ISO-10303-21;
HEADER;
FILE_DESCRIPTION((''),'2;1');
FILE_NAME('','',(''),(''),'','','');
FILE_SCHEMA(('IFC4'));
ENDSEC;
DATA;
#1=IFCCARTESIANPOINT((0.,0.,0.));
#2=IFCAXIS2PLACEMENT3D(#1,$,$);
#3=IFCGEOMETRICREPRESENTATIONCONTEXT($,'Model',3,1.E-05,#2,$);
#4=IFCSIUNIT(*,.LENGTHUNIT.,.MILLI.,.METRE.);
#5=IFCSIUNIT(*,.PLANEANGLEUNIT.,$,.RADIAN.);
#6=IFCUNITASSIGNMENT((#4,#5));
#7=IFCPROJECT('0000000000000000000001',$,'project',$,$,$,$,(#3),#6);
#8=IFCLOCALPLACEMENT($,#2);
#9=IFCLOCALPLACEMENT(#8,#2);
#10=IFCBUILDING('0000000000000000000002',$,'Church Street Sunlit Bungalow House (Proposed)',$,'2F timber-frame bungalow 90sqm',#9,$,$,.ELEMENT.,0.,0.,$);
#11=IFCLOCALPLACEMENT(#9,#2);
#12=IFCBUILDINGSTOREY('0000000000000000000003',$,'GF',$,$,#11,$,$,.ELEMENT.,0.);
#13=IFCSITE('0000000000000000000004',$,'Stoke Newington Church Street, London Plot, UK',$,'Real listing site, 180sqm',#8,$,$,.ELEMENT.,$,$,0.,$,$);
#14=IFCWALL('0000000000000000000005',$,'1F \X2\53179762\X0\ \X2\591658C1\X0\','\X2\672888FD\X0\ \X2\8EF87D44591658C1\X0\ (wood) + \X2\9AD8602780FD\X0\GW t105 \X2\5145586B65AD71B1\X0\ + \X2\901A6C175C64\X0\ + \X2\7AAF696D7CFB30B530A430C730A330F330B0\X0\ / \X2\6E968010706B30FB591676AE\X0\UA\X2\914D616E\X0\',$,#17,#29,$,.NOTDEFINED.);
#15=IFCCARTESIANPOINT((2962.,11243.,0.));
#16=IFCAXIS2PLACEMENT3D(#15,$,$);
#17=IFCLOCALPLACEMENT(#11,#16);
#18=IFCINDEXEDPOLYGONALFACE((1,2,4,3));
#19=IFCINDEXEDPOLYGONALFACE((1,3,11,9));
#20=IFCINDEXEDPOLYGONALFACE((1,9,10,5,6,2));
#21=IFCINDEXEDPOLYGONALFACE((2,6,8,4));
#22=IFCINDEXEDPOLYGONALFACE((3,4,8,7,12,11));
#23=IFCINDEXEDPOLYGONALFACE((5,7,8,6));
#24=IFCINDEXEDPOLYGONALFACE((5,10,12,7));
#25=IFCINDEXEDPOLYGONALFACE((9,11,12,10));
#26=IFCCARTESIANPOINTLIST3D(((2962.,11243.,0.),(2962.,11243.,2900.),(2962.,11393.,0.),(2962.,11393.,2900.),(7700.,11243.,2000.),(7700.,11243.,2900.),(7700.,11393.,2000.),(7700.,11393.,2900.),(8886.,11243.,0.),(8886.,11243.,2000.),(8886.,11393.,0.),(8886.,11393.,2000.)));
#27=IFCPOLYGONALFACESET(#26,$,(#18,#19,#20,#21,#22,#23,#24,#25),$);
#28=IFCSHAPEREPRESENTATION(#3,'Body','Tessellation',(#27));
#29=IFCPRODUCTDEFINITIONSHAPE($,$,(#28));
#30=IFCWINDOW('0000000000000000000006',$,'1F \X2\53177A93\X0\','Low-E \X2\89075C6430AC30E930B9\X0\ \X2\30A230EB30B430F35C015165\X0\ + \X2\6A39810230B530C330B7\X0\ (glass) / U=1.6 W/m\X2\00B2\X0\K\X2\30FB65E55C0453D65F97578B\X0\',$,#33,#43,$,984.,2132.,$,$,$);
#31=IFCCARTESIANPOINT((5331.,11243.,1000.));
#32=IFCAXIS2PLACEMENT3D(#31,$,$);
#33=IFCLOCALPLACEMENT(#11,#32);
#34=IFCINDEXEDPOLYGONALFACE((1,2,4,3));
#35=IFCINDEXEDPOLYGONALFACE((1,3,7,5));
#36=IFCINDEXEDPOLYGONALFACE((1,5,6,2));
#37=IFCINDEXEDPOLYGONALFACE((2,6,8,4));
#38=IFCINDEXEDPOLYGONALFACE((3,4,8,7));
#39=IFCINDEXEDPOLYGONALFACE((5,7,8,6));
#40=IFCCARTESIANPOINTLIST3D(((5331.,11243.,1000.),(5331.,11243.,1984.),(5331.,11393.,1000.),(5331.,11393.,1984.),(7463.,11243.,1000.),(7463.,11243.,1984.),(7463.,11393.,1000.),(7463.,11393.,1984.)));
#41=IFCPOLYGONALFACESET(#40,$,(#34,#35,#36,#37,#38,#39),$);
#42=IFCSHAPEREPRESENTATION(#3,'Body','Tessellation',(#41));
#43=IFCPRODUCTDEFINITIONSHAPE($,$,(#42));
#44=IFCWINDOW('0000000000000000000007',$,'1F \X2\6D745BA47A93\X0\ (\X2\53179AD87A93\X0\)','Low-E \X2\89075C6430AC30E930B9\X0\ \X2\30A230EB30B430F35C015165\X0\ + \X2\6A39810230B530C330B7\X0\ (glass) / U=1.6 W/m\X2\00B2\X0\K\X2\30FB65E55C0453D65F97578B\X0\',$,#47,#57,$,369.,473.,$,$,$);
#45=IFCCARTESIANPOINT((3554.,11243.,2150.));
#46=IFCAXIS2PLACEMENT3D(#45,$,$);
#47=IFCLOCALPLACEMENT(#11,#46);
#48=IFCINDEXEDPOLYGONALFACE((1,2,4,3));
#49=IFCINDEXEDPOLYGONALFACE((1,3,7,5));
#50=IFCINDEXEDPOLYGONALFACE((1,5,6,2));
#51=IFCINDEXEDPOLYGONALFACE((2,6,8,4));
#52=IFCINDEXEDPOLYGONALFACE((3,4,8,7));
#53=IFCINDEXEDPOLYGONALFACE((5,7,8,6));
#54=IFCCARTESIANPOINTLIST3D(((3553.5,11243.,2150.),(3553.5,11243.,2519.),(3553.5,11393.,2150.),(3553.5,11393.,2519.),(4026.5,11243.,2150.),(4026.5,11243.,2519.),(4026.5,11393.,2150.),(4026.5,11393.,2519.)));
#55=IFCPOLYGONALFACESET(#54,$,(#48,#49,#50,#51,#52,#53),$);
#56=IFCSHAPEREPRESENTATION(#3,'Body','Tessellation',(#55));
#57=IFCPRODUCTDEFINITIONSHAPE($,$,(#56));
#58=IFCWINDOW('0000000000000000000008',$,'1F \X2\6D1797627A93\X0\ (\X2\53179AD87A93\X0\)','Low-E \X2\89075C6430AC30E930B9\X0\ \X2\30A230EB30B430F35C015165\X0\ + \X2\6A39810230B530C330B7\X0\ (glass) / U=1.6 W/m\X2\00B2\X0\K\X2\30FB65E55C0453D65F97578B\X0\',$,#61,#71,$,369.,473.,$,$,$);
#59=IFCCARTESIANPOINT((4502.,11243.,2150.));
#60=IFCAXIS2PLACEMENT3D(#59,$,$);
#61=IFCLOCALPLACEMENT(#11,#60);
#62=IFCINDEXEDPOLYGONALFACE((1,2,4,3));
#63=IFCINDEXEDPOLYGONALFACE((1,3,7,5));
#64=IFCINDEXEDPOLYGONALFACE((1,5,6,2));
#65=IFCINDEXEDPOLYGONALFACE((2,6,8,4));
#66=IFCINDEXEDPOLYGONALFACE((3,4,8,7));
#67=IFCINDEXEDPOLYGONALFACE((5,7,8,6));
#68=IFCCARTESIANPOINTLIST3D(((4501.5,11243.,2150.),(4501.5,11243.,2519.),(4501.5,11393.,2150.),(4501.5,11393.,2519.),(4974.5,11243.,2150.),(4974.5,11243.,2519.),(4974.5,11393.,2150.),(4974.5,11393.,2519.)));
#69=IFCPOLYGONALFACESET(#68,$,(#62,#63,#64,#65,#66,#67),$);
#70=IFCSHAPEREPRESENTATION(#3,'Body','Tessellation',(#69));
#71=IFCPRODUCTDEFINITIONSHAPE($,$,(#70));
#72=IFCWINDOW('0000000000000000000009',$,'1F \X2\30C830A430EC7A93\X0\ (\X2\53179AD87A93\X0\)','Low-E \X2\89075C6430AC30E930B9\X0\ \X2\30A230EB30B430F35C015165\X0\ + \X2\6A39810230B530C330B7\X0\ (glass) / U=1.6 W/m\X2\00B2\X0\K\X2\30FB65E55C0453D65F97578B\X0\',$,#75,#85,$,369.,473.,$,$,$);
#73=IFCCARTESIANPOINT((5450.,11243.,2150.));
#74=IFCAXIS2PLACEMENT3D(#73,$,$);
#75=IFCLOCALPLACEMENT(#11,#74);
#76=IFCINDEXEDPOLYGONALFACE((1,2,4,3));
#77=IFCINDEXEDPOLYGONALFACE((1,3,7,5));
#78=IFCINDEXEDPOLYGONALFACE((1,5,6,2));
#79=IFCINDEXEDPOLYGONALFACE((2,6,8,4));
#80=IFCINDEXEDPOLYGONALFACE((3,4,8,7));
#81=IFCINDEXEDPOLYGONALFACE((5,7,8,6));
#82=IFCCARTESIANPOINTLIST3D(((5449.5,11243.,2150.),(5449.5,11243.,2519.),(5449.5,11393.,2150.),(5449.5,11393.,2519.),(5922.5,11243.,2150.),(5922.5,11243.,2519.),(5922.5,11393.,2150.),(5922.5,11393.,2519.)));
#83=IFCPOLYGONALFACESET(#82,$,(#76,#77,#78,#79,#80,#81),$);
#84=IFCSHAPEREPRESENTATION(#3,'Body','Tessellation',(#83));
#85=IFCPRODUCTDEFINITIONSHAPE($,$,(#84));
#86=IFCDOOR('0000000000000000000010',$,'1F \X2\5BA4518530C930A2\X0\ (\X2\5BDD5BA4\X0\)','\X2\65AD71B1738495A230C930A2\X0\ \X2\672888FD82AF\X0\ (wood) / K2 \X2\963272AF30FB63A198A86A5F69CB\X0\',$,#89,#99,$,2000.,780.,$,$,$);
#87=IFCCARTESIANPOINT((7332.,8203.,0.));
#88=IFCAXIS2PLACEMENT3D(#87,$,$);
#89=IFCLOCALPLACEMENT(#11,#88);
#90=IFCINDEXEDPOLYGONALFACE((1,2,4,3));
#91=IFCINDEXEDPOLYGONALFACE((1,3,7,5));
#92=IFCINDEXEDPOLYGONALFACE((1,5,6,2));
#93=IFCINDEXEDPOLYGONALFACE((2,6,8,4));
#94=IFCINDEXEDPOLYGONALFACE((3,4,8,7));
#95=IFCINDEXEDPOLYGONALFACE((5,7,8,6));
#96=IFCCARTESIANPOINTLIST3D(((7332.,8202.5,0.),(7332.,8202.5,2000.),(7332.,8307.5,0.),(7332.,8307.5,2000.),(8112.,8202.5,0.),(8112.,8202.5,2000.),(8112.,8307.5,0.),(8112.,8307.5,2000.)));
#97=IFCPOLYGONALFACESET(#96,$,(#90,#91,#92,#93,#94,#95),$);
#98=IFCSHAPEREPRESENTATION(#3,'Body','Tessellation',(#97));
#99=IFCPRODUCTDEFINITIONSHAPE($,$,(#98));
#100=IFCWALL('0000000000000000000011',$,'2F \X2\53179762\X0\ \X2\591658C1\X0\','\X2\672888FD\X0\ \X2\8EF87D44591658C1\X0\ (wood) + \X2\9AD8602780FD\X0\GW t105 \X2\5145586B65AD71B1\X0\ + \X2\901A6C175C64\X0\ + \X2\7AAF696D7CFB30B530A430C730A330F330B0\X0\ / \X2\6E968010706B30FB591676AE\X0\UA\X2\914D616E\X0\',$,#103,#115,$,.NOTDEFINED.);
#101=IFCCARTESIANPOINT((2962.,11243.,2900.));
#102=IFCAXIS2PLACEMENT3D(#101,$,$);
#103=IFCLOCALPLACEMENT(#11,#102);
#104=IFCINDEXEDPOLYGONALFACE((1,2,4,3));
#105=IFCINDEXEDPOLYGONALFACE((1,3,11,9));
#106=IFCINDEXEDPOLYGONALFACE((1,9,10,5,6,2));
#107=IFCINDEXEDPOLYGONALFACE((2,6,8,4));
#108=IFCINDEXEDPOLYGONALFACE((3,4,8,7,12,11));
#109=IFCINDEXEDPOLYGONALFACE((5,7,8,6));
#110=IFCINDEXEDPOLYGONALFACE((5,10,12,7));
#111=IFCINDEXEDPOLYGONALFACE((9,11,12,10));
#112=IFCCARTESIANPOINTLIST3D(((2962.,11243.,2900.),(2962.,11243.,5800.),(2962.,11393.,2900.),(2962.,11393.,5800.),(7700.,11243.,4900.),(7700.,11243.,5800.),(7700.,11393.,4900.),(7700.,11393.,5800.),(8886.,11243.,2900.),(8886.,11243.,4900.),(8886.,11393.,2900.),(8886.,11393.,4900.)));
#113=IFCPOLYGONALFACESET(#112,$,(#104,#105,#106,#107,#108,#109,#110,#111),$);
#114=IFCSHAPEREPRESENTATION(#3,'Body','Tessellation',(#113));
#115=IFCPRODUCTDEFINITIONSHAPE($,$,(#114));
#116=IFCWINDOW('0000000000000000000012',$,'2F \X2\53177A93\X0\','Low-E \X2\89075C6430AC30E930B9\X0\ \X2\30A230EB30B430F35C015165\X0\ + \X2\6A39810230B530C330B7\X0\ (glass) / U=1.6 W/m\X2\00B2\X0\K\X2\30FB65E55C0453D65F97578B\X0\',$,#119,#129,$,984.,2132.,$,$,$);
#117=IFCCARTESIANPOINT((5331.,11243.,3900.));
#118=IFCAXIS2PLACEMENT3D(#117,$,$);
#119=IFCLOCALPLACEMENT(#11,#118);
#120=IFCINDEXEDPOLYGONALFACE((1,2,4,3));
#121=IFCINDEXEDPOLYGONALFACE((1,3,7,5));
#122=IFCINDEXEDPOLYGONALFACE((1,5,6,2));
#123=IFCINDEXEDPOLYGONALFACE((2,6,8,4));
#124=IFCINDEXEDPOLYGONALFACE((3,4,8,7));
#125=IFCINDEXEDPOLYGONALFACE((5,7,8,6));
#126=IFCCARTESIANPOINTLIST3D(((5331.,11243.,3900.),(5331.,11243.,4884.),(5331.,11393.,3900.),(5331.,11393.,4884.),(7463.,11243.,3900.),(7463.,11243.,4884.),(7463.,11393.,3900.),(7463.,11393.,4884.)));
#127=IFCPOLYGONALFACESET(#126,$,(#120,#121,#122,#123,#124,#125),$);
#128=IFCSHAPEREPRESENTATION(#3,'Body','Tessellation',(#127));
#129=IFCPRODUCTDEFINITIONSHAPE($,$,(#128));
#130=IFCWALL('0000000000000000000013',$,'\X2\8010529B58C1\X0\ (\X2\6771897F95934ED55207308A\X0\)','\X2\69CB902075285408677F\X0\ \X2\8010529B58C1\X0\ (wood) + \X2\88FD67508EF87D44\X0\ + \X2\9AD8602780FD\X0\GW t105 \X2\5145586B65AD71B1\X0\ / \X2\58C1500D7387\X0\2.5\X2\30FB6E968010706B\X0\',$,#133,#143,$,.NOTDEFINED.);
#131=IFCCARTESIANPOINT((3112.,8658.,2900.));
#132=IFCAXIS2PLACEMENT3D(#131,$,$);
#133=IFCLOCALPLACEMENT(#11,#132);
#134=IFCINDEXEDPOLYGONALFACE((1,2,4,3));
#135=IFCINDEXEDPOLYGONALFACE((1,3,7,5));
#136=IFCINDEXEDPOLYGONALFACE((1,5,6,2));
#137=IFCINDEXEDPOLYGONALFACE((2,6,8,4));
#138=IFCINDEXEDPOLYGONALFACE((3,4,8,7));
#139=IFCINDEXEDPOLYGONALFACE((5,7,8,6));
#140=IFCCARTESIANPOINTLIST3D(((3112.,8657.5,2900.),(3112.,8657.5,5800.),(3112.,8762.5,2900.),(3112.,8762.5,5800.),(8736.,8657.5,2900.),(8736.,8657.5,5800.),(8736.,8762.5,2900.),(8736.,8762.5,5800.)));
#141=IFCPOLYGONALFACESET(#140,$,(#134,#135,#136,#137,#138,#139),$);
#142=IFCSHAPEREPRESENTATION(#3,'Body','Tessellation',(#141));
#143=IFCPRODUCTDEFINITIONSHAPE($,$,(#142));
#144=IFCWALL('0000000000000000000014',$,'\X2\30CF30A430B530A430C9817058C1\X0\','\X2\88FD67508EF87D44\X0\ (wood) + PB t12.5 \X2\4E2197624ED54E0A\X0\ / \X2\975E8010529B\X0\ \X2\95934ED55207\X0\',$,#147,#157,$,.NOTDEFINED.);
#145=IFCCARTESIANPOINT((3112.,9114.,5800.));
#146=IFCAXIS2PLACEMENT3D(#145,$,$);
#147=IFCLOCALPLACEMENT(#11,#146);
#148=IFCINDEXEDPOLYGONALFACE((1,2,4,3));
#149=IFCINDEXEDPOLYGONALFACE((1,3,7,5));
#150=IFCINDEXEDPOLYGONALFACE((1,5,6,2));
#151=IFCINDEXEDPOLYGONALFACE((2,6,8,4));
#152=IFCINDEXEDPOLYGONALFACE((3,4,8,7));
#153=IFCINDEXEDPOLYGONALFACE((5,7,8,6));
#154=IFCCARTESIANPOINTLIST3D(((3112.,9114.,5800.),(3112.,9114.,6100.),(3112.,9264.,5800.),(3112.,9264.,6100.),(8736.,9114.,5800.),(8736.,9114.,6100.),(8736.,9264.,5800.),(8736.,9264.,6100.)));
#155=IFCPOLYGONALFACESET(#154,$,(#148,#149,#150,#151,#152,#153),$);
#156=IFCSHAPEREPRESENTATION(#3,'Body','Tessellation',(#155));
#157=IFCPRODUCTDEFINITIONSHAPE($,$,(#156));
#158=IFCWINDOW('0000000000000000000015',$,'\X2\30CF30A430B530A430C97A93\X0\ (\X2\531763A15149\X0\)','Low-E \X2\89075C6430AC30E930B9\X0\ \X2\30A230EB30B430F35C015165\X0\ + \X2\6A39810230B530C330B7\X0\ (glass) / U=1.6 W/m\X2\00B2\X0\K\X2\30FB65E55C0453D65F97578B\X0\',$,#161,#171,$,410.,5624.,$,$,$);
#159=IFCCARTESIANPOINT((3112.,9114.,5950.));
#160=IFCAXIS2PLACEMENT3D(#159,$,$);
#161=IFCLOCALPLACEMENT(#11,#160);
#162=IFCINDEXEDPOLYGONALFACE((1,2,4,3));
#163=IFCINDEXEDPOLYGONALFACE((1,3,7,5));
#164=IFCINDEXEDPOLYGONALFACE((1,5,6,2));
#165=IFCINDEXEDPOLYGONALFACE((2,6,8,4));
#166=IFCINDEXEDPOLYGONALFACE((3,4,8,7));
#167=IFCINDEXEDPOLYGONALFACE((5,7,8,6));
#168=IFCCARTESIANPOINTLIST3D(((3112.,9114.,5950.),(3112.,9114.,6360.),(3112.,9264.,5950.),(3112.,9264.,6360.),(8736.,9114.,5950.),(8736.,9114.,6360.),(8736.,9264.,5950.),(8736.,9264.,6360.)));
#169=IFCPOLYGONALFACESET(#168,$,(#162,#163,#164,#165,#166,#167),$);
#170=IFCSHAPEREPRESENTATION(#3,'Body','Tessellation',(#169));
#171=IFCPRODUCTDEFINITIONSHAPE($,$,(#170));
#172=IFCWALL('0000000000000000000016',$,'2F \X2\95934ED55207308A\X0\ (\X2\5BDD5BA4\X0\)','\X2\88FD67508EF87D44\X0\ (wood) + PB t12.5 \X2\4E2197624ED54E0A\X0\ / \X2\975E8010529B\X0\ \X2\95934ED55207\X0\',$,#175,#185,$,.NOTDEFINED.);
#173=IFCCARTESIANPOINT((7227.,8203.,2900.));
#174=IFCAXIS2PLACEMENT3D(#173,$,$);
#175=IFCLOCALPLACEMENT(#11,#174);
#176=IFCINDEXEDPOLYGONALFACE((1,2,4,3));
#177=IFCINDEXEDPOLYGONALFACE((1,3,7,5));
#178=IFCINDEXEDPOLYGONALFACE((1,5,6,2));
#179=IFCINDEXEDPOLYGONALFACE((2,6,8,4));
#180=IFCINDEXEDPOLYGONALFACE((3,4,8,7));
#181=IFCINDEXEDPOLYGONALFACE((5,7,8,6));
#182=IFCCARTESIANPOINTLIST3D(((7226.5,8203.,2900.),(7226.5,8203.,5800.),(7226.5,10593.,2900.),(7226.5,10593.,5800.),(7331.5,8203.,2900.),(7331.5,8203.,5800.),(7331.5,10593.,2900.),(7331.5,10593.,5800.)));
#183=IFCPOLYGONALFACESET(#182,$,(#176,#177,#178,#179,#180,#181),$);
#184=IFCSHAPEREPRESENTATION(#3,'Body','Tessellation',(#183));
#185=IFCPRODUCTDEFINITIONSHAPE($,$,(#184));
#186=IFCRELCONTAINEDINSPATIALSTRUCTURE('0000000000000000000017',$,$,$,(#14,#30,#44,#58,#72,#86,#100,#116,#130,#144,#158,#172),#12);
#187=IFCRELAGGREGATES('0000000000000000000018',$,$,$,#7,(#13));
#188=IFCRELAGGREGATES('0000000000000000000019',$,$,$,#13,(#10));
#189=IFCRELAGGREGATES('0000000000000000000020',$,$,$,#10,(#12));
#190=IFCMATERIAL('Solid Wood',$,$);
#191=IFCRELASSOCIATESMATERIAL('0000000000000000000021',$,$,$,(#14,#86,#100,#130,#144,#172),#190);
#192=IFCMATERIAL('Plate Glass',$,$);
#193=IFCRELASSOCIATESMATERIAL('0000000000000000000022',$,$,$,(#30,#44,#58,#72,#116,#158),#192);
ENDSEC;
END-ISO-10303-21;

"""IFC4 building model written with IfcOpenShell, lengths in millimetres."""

from ifc_helpers import new_model, si_unit, frame, frame_2d, origin, place, context, project, spatial, rectangle, extrude, material, element, fill, save


model = new_model("IFC4")

# Units and contexts
model_context = context("Model", 3, precision=1e-05, world=origin())
ifc_project = project(units=[si_unit("LENGTHUNIT", "METRE", prefix="MILLI"), si_unit("PLANEANGLEUNIT", "RADIAN")], contexts=[model_context])

# Site, building, storey
site_placement = place(None, origin())
site = spatial("IfcSite", under=ifc_project, at=site_placement, Name="Stoke Newington Church Street, London Plot, UK", ObjectType="Real listing site, 180sqm", CompositionType="ELEMENT", RefElevation=0.0)
building_placement = place(site_placement, origin())
building = spatial("IfcBuilding", under=site, at=building_placement, Name="Church Street Sunlit Bungalow House (Proposed)", ObjectType="2F timber-frame bungalow 90sqm", CompositionType="ELEMENT", ElevationOfRefHeight=0.0, ElevationOfTerrain=0.0)
storey_placement = place(building_placement, origin())
storey = spatial("IfcBuildingStorey", under=building, at=storey_placement, Name="GF", CompositionType="ELEMENT", Elevation=0.0)

# Wall, openings, windows
ifc_material_1 = material(Name="Solid Wood")
wall_1_placement = place(storey_placement, frame((2962.0, 11243.0, 0.0)))
wall_1 = element("IfcWall", 1, at=wall_1_placement, inside=storey, material=ifc_material_1, Name="1F 北面 外壁", Description="木製 軸組外壁 (wood) + 高性能GW t105 充填断熱 + 通気層 + 窯業系サイディング / 準耐火・外皮UA配慮", PredefinedType="NOTDEFINED", context=model_context, shape_type="SweptSolid", body=[
    extrude(rectangle(XDim=5924.0, YDim=150.0, at=frame_2d((2962.0, 75.0))), frame((2962.0, 11243.0, 0.0)), (0.0, 0.0, 1.0), 2900.0),
])
opening_1_placement = place(storey_placement, frame((5331.0, 11243.0, 1000.0)))
opening_1 = element("IfcOpeningElement", 2, at=opening_1_placement, cuts=wall_1, PredefinedType="NOTDEFINED", context=model_context, shape_type="SweptSolid", body=[
    extrude(rectangle(XDim=2132.0, YDim=150.0, at=frame_2d((1066.0, 75.0))), frame((5331.0, 11243.0, 1000.0)), (0.0, 0.0, 1.0), 984.0),
])
opening_2_placement = place(storey_placement, frame((3554.0, 11243.0, 2150.0)))
opening_2 = element("IfcOpeningElement", 3, at=opening_2_placement, cuts=wall_1, PredefinedType="NOTDEFINED", context=model_context, shape_type="SweptSolid", body=[
    extrude(rectangle(XDim=473.0, YDim=150.0, at=frame_2d((236.0, 75.0))), frame((3554.0, 11243.0, 2150.0)), (0.0, 0.0, 1.0), 369.0),
])
opening_3_placement = place(storey_placement, frame((4502.0, 11243.0, 2150.0)))
opening_3 = element("IfcOpeningElement", 4, at=opening_3_placement, cuts=wall_1, PredefinedType="NOTDEFINED", context=model_context, shape_type="SweptSolid", body=[
    extrude(rectangle(XDim=473.0, YDim=150.0, at=frame_2d((236.0, 75.0))), frame((4502.0, 11243.0, 2150.0)), (0.0, 0.0, 1.0), 369.0),
])
opening_4_placement = place(storey_placement, frame((5450.0, 11243.0, 2150.0)))
opening_4 = element("IfcOpeningElement", 5, at=opening_4_placement, cuts=wall_1, PredefinedType="NOTDEFINED", context=model_context, shape_type="SweptSolid", body=[
    extrude(rectangle(XDim=473.0, YDim=150.0, at=frame_2d((236.0, 75.0))), frame((5450.0, 11243.0, 2150.0)), (0.0, 0.0, 1.0), 369.0),
])
ifc_material_2 = material(Name="Plate Glass")
window_1_placement = place(storey_placement, frame((5331.0, 11243.0, 1000.0)))
window_1 = element("IfcWindow", 6, at=window_1_placement, inside=storey, material=ifc_material_2, Name="1F 北窓", Description="Low-E 複層ガラス アルゴン封入 + 樹脂サッシ (glass) / U=1.6 W/m²K・日射取得型", OverallHeight=984.0, OverallWidth=2132.0, context=model_context, shape_type="SweptSolid", body=[
    extrude(rectangle(XDim=2132.0, YDim=150.0, at=frame_2d((1066.0, 75.0))), frame((5331.0, 11243.0, 1000.0)), (0.0, 0.0, 1.0), 984.0),
])
fill(opening_1, window_1)
window_2_placement = place(storey_placement, frame((3554.0, 11243.0, 2150.0)))
window_2 = element("IfcWindow", 7, at=window_2_placement, inside=storey, material=ifc_material_2, Name="1F 浴室窓 (北高窓)", Description="Low-E 複層ガラス アルゴン封入 + 樹脂サッシ (glass) / U=1.6 W/m²K・日射取得型", OverallHeight=369.0, OverallWidth=473.0, context=model_context, shape_type="SweptSolid", body=[
    extrude(rectangle(XDim=473.0, YDim=150.0, at=frame_2d((236.0, 75.0))), frame((3554.0, 11243.0, 2150.0)), (0.0, 0.0, 1.0), 369.0),
])
fill(opening_2, window_2)
window_3_placement = place(storey_placement, frame((4502.0, 11243.0, 2150.0)))
window_3 = element("IfcWindow", 8, at=window_3_placement, inside=storey, material=ifc_material_2, Name="1F 洗面窓 (北高窓)", Description="Low-E 複層ガラス アルゴン封入 + 樹脂サッシ (glass) / U=1.6 W/m²K・日射取得型", OverallHeight=369.0, OverallWidth=473.0, context=model_context, shape_type="SweptSolid", body=[
    extrude(rectangle(XDim=473.0, YDim=150.0, at=frame_2d((236.0, 75.0))), frame((4502.0, 11243.0, 2150.0)), (0.0, 0.0, 1.0), 369.0),
])
fill(opening_3, window_3)
window_4_placement = place(storey_placement, frame((5450.0, 11243.0, 2150.0)))
window_4 = element("IfcWindow", 9, at=window_4_placement, inside=storey, material=ifc_material_2, Name="1F トイレ窓 (北高窓)", Description="Low-E 複層ガラス アルゴン封入 + 樹脂サッシ (glass) / U=1.6 W/m²K・日射取得型", OverallHeight=369.0, OverallWidth=473.0, context=model_context, shape_type="SweptSolid", body=[
    extrude(rectangle(XDim=473.0, YDim=150.0, at=frame_2d((236.0, 75.0))), frame((5450.0, 11243.0, 2150.0)), (0.0, 0.0, 1.0), 369.0),
])
fill(opening_4, window_4)

# Door
door_1_placement = place(storey_placement, frame((7332.0, 8203.0, 0.0)))
element("IfcDoor", 10, at=door_1_placement, inside=storey, material=ifc_material_1, Name="1F 室内ドア (寝室)", Description="断熱玄関ドア 木製芯 (wood) / K2 防犯・採風機構", OverallHeight=2000.0, OverallWidth=780.0, context=model_context, shape_type="SweptSolid", body=[
    extrude(rectangle(XDim=780.0, YDim=105.0, at=frame_2d((390.0, 52.0))), frame((7332.0, 8203.0, 0.0)), (0.0, 0.0, 1.0), 2000.0),
])

# Wall, opening, window
wall_2_placement = place(storey_placement, frame((2962.0, 11243.0, 2900.0)))
wall_2 = element("IfcWall", 11, at=wall_2_placement, inside=storey, material=ifc_material_1, Name="2F 北面 外壁", Description="木製 軸組外壁 (wood) + 高性能GW t105 充填断熱 + 通気層 + 窯業系サイディング / 準耐火・外皮UA配慮", PredefinedType="NOTDEFINED", context=model_context, shape_type="SweptSolid", body=[
    extrude(rectangle(XDim=5924.0, YDim=150.0, at=frame_2d((2962.0, 75.0))), frame((2962.0, 11243.0, 2900.0)), (0.0, 0.0, 1.0), 2900.0),
])
opening_5_placement = place(storey_placement, frame((5331.0, 11243.0, 3900.0)))
opening_5 = element("IfcOpeningElement", 12, at=opening_5_placement, cuts=wall_2, PredefinedType="NOTDEFINED", context=model_context, shape_type="SweptSolid", body=[
    extrude(rectangle(XDim=2132.0, YDim=150.0, at=frame_2d((1066.0, 75.0))), frame((5331.0, 11243.0, 3900.0)), (0.0, 0.0, 1.0), 984.0),
])
window_5_placement = place(storey_placement, frame((5331.0, 11243.0, 3900.0)))
window_5 = element("IfcWindow", 13, at=window_5_placement, inside=storey, material=ifc_material_2, Name="2F 北窓", Description="Low-E 複層ガラス アルゴン封入 + 樹脂サッシ (glass) / U=1.6 W/m²K・日射取得型", OverallHeight=984.0, OverallWidth=2132.0, context=model_context, shape_type="SweptSolid", body=[
    extrude(rectangle(XDim=2132.0, YDim=150.0, at=frame_2d((1066.0, 75.0))), frame((5331.0, 11243.0, 3900.0)), (0.0, 0.0, 1.0), 984.0),
])
fill(opening_5, window_5)

# Wall
wall_3_placement = place(storey_placement, frame((3112.0, 8658.0, 2900.0)))
element("IfcWall", 14, at=wall_3_placement, inside=storey, material=ifc_material_1, Name="耐力壁 (東西間仕切り)", Description="構造用合板 耐力壁 (wood) + 製材軸組 + 高性能GW t105 充填断熱 / 壁倍率2.5・準耐火", PredefinedType="NOTDEFINED", context=model_context, shape_type="SweptSolid", body=[
    extrude(rectangle(XDim=5624.0, YDim=105.0, at=frame_2d((2812.0, 52.0))), frame((3112.0, 8658.0, 2900.0)), (0.0, 0.0, 1.0), 2900.0),
])

# Wall, opening, window
wall_4_placement = place(storey_placement, frame((3112.0, 9114.0, 5800.0)))
wall_4 = element("IfcWall", 15, at=wall_4_placement, inside=storey, material=ifc_material_1, Name="ハイサイド腰壁", Description="製材軸組 (wood) + PB t12.5 両面仕上 / 非耐力 間仕切", PredefinedType="NOTDEFINED", context=model_context, shape_type="SweptSolid", body=[
    extrude(rectangle(XDim=5624.0, YDim=150.0, at=frame_2d((2812.0, 75.0))), frame((3112.0, 9114.0, 5800.0)), (0.0, 0.0, 1.0), 700.0),
])
opening_6_placement = place(storey_placement, frame((3112.0, 9114.0, 5950.0)))
opening_6 = element("IfcOpeningElement", 16, at=opening_6_placement, cuts=wall_4, PredefinedType="NOTDEFINED", context=model_context, shape_type="SweptSolid", body=[
    extrude(rectangle(XDim=5624.0, YDim=150.0, at=frame_2d((2812.0, 75.0))), frame((3112.0, 9114.0, 5950.0)), (0.0, 0.0, 1.0), 410.0),
])
window_6_placement = place(storey_placement, frame((3112.0, 9114.0, 5950.0)))
window_6 = element("IfcWindow", 17, at=window_6_placement, inside=storey, material=ifc_material_2, Name="ハイサイド窓 (北採光)", Description="Low-E 複層ガラス アルゴン封入 + 樹脂サッシ (glass) / U=1.6 W/m²K・日射取得型", OverallHeight=410.0, OverallWidth=5624.0, context=model_context, shape_type="SweptSolid", body=[
    extrude(rectangle(XDim=5624.0, YDim=150.0, at=frame_2d((2812.0, 75.0))), frame((3112.0, 9114.0, 5950.0)), (0.0, 0.0, 1.0), 410.0),
])
fill(opening_6, window_6)

# Wall
wall_5_placement = place(storey_placement, frame((7227.0, 8203.0, 2900.0)))
element("IfcWall", 18, at=wall_5_placement, inside=storey, material=ifc_material_1, Name="2F 間仕切り (寝室)", Description="製材軸組 (wood) + PB t12.5 両面仕上 / 非耐力 間仕切", PredefinedType="NOTDEFINED", context=model_context, shape_type="SweptSolid", body=[
    extrude(rectangle(XDim=105.0, YDim=2390.0, at=frame_2d((52.0, 1195.0))), frame((7227.0, 8203.0, 2900.0)), (0.0, 0.0, 1.0), 2900.0),
])

save(model, "model.ifc")
